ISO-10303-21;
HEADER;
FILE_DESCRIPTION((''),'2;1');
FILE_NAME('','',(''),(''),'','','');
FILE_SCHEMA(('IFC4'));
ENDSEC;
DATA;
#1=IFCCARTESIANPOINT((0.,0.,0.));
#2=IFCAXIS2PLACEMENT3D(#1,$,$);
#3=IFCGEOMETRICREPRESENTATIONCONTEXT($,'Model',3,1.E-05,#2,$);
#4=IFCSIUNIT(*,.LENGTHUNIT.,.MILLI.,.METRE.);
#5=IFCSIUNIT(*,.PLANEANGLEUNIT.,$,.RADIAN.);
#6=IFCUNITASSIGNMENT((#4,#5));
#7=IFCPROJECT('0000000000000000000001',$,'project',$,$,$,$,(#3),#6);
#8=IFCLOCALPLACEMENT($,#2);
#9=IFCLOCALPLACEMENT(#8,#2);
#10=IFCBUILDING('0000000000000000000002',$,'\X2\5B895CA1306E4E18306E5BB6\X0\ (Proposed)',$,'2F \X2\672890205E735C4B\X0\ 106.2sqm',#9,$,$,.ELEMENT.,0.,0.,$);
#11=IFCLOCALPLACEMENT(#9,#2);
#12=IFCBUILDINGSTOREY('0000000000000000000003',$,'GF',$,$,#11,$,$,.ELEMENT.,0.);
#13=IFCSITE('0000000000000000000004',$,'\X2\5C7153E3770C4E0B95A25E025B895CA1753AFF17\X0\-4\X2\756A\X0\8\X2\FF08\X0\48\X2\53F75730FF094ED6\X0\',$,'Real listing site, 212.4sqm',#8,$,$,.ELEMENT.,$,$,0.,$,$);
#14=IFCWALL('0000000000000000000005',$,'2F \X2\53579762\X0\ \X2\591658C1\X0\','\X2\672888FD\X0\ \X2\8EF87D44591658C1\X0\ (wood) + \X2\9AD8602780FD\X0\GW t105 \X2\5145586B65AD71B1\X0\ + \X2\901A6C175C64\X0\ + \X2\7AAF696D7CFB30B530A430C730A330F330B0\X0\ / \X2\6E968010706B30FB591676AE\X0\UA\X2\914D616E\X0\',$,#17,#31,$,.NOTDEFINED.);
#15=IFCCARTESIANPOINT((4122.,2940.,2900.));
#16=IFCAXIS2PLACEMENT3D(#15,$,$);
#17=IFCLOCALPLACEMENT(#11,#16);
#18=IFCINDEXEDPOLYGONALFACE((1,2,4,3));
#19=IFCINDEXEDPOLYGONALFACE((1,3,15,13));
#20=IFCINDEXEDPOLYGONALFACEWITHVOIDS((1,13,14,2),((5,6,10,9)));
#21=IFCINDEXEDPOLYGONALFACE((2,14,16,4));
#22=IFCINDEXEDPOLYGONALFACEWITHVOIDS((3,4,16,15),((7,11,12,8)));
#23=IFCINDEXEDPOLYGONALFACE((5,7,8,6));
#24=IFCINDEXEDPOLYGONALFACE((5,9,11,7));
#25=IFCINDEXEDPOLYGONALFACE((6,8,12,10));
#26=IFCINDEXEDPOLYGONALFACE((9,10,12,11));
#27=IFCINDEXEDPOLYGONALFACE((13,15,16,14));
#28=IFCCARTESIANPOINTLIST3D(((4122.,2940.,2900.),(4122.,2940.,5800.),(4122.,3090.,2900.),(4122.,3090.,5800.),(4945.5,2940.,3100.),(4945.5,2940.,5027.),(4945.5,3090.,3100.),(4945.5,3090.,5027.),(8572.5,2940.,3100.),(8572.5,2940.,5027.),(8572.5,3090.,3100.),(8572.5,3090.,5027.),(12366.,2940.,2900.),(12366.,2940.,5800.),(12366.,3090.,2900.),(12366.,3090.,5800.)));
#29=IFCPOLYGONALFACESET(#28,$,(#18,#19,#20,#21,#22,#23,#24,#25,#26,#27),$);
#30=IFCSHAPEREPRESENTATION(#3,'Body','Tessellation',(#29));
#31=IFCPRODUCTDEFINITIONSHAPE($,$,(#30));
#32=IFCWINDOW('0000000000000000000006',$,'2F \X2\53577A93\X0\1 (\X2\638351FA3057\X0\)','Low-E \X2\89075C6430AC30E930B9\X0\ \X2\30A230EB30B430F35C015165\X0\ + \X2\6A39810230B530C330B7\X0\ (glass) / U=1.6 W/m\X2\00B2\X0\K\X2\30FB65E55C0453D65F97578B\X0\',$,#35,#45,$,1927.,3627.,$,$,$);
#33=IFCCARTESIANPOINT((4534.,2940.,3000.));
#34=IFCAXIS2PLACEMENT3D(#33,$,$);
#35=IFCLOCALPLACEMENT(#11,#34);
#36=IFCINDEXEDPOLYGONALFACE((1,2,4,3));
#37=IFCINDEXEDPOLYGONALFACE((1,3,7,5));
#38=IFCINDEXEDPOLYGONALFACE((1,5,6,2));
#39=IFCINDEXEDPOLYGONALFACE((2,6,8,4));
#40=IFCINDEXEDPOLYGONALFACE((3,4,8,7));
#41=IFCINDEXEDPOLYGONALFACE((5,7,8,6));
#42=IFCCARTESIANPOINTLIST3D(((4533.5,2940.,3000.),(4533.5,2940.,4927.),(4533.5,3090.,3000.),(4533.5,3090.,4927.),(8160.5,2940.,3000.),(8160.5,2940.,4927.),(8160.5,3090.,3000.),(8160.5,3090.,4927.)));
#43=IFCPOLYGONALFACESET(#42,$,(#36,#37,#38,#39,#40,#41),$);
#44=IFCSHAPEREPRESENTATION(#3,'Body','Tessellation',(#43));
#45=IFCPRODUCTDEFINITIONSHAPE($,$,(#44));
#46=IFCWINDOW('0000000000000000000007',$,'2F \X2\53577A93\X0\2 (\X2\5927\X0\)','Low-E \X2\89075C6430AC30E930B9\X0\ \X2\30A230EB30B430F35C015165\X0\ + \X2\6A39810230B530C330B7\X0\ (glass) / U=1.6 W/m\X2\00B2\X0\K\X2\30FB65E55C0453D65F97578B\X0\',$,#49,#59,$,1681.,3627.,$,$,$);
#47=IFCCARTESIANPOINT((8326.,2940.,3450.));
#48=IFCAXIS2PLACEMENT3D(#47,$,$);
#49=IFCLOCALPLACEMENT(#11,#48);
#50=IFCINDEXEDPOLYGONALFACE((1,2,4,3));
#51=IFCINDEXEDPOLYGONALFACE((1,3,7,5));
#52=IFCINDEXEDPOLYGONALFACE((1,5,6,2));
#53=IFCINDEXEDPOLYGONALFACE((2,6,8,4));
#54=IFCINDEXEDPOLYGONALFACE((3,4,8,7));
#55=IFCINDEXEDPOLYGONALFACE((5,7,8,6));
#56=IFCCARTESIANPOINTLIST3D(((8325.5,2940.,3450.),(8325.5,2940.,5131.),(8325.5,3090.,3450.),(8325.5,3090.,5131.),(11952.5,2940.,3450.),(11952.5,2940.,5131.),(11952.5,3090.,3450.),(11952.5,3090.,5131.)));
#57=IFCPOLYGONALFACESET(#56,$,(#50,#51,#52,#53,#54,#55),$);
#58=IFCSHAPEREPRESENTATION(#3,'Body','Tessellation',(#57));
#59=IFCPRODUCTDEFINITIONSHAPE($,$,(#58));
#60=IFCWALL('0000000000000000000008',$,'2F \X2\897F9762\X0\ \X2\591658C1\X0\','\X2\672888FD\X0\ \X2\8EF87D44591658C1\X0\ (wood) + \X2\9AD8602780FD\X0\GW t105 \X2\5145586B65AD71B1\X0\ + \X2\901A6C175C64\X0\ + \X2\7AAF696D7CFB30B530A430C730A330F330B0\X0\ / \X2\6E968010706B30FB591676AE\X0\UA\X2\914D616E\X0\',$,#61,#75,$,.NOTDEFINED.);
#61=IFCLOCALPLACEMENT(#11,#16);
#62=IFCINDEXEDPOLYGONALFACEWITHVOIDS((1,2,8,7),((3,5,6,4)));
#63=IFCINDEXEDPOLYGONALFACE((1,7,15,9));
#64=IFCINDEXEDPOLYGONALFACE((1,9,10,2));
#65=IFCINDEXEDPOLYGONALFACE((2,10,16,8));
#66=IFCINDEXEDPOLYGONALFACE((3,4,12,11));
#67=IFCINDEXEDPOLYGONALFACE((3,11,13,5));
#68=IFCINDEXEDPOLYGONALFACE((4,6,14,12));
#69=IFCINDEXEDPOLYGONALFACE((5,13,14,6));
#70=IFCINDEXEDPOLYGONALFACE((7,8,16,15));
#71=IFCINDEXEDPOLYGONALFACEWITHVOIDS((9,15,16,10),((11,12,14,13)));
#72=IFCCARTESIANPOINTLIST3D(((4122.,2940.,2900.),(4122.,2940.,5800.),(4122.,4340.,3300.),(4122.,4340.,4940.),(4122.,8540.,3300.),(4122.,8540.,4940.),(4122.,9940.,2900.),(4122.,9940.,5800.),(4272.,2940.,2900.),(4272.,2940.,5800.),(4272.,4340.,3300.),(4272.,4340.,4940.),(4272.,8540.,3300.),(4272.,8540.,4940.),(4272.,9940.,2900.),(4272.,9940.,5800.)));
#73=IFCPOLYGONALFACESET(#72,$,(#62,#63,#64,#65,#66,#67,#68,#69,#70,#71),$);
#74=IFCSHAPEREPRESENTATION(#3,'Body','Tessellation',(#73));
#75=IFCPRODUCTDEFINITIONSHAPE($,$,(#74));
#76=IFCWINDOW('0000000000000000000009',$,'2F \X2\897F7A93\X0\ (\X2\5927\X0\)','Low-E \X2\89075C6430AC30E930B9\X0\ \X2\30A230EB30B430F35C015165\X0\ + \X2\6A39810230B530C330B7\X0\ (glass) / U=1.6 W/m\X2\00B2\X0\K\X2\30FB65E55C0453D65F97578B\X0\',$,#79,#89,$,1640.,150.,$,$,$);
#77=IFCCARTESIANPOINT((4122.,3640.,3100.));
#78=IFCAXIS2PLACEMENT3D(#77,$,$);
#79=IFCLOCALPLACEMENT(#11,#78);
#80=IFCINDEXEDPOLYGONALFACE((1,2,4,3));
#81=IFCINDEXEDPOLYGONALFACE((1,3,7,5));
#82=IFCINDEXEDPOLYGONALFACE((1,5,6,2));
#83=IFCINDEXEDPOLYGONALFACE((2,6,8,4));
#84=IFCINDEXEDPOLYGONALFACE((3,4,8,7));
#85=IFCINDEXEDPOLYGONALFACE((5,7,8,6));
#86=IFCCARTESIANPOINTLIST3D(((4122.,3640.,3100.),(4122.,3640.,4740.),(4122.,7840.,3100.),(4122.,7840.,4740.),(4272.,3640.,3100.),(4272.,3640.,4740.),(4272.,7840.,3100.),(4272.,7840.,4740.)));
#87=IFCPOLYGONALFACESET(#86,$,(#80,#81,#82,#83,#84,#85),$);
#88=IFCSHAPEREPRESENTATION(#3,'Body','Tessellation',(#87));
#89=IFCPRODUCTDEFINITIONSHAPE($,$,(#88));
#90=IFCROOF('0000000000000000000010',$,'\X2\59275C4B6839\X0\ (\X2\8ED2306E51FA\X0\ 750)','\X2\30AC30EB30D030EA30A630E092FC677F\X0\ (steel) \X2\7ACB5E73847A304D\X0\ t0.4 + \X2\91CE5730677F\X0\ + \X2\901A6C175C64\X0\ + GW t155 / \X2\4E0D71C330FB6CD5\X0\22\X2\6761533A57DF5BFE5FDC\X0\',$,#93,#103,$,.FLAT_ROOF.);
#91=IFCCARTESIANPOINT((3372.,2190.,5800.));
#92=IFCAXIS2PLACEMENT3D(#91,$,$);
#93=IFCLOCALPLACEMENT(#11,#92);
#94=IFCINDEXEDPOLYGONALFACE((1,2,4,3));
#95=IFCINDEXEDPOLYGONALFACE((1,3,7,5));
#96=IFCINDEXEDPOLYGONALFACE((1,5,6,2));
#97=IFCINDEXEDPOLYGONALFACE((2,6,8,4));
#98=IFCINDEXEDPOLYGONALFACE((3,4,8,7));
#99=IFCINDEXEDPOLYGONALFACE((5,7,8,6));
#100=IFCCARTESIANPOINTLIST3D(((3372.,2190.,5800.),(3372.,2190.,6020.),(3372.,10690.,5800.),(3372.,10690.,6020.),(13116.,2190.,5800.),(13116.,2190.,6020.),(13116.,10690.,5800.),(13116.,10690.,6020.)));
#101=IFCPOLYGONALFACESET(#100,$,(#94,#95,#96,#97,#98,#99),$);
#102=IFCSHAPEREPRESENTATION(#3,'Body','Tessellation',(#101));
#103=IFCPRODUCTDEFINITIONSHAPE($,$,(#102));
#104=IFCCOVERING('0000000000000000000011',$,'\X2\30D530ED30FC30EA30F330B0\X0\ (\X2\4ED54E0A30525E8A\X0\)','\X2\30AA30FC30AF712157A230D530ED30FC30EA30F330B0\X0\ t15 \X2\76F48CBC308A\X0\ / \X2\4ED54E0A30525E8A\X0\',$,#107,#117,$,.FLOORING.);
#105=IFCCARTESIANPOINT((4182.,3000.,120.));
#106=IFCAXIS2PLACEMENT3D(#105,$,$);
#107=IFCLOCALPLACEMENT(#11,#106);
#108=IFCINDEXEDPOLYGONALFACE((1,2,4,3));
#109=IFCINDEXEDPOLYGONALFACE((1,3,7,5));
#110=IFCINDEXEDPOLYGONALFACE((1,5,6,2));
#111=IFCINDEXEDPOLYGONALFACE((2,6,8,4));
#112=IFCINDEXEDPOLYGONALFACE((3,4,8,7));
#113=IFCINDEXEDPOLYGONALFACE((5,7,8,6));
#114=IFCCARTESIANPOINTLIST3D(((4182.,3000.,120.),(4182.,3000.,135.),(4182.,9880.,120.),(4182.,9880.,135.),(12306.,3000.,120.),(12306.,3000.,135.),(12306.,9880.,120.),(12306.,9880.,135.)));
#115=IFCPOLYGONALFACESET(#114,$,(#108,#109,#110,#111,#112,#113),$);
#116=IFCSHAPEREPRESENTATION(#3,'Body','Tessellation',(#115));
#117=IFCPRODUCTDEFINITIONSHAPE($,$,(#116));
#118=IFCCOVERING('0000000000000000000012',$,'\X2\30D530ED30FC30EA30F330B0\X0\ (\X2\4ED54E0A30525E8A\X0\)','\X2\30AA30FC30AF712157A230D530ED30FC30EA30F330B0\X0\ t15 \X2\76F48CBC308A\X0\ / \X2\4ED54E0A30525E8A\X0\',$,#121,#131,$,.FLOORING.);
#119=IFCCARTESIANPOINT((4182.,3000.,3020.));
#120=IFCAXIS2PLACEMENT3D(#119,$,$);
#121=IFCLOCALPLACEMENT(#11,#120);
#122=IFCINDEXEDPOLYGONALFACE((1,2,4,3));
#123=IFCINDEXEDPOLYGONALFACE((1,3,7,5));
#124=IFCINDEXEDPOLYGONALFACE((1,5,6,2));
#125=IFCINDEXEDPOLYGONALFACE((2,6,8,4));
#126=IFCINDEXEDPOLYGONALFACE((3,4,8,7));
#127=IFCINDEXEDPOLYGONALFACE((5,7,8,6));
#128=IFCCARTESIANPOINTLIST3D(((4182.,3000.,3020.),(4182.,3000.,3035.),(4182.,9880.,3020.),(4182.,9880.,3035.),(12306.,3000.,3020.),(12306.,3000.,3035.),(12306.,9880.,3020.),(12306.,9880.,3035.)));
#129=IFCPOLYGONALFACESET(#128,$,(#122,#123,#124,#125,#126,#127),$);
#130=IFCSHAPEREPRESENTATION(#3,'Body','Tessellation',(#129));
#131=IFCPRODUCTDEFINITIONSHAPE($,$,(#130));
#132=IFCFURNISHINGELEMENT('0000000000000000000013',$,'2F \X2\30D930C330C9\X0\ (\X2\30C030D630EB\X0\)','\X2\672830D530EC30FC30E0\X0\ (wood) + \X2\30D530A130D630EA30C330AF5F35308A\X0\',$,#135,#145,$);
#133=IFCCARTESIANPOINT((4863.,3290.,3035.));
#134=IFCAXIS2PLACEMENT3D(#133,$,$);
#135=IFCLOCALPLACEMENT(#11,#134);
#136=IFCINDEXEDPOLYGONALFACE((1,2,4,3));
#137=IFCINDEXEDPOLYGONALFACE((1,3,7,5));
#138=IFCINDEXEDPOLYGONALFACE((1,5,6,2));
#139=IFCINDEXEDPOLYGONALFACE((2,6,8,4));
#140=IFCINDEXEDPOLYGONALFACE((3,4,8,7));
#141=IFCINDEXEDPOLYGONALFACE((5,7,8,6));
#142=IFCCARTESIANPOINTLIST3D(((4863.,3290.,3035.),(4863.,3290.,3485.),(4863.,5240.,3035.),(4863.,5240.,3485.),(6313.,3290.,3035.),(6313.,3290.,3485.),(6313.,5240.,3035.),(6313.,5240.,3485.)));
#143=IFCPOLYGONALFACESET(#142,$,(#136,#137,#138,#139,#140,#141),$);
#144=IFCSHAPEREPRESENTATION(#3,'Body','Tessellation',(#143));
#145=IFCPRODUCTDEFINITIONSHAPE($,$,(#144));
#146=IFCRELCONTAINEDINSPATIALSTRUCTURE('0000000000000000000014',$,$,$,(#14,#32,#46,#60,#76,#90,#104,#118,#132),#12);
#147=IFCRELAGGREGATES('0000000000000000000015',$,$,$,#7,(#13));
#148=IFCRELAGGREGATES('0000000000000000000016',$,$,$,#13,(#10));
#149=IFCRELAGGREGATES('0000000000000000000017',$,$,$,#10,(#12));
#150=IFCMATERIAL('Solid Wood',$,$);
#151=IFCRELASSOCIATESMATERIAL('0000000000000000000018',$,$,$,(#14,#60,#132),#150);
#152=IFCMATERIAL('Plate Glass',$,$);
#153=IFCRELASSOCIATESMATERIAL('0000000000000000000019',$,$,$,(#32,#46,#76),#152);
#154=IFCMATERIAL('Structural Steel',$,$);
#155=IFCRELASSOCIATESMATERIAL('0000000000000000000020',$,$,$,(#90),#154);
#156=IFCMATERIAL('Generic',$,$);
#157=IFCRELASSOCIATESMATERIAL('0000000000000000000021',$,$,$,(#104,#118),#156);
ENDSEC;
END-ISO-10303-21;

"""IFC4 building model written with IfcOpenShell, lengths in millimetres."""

from ifc_helpers import new_model, si_unit, frame, frame_2d, origin, place, context, project, spatial, rectangle, extrude, material, element, fill, save


model = new_model("IFC4")

# Units and contexts
model_context = context("Model", 3, precision=1e-05, world=origin())
ifc_project = project(units=[si_unit("LENGTHUNIT", "METRE", prefix="MILLI"), si_unit("PLANEANGLEUNIT", "RADIAN")], contexts=[model_context])

# Site, building, storey
site_placement = place(None, origin())
site = spatial("IfcSite", under=ifc_project, at=site_placement, Name="山口県下関市安岡町７-4番8（48号地）他", ObjectType="Real listing site, 212.4sqm", CompositionType="ELEMENT", RefElevation=0.0)
building_placement = place(site_placement, origin())
building = spatial("IfcBuilding", under=site, at=building_placement, Name="安岡の丘の家 (Proposed)", ObjectType="2F 木造平屋 106.2sqm", CompositionType="ELEMENT", ElevationOfRefHeight=0.0, ElevationOfTerrain=0.0)
storey_placement = place(building_placement, origin())
storey = spatial("IfcBuildingStorey", under=building, at=storey_placement, Name="GF", CompositionType="ELEMENT", Elevation=0.0)

# Shared definitions
ifc_material_1 = material(Name="Solid Wood")

# Shared definitions
ifc_material_2 = material(Name="Plate Glass")

# Wall, openings, windows
wall_1_placement = place(storey_placement, frame((4122.0, 2940.0, 2900.0)))
wall_1 = element("IfcWall", 1, at=wall_1_placement, inside=storey, material=ifc_material_1, Name="2F 南面 外壁", Description="木製 軸組外壁 (wood) + 高性能GW t105 充填断熱 + 通気層 + 窯業系サイディング / 準耐火・外皮UA配慮", PredefinedType="NOTDEFINED", context=model_context, shape_type="SweptSolid", body=[
    extrude(rectangle(XDim=8244.0, YDim=150.0, at=frame_2d((4122.0, 75.0))), frame((4122.0, 2940.0, 2900.0)), (0.0, 0.0, 1.0), 2900.0),
])
opening_1_placement = place(storey_placement, frame((4534.0, 2940.0, 3000.0)))
opening_1 = element("IfcOpeningElement", 2, at=opening_1_placement, cuts=wall_1, PredefinedType="NOTDEFINED", context=model_context, shape_type="SweptSolid", body=[
    extrude(rectangle(XDim=3627.0, YDim=150.0, at=frame_2d((1813.0, 75.0))), frame((4534.0, 2940.0, 3000.0)), (0.0, 0.0, 1.0), 1927.0),
])
opening_2_placement = place(storey_placement, frame((8326.0, 2940.0, 3450.0)))
opening_2 = element("IfcOpeningElement", 3, at=opening_2_placement, cuts=wall_1, PredefinedType="NOTDEFINED", context=model_context, shape_type="SweptSolid", body=[
    extrude(rectangle(XDim=3627.0, YDim=150.0, at=frame_2d((1813.0, 75.0))), frame((8326.0, 2940.0, 3450.0)), (0.0, 0.0, 1.0), 1681.0),
])
window_1_placement = place(storey_placement, frame((4534.0, 2940.0, 3000.0)))
window_1 = element("IfcWindow", 4, at=window_1_placement, inside=storey, material=ifc_material_2, Name="2F 南窓1 (掃出し)", Description="Low-E 複層ガラス アルゴン封入 + 樹脂サッシ (glass) / U=1.6 W/m²K・日射取得型", OverallHeight=1927.0, OverallWidth=3627.0, context=model_context, shape_type="SweptSolid", body=[
    extrude(rectangle(XDim=3627.0, YDim=150.0, at=frame_2d((1813.0, 75.0))), frame((4534.0, 2940.0, 3000.0)), (0.0, 0.0, 1.0), 1927.0),
])
fill(opening_1, window_1)
window_2_placement = place(storey_placement, frame((8326.0, 2940.0, 3450.0)))
window_2 = element("IfcWindow", 5, at=window_2_placement, inside=storey, material=ifc_material_2, Name="2F 南窓2 (大)", Description="Low-E 複層ガラス アルゴン封入 + 樹脂サッシ (glass) / U=1.6 W/m²K・日射取得型", OverallHeight=1681.0, OverallWidth=3627.0, context=model_context, shape_type="SweptSolid", body=[
    extrude(rectangle(XDim=3627.0, YDim=150.0, at=frame_2d((1813.0, 75.0))), frame((8326.0, 2940.0, 3450.0)), (0.0, 0.0, 1.0), 1681.0),
])
fill(opening_2, window_2)

# Wall, opening, window
wall_2_placement = place(storey_placement, frame((4122.0, 2940.0, 2900.0)))
wall_2 = element("IfcWall", 6, at=wall_2_placement, inside=storey, material=ifc_material_1, Name="2F 西面 外壁", Description="木製 軸組外壁 (wood) + 高性能GW t105 充填断熱 + 通気層 + 窯業系サイディング / 準耐火・外皮UA配慮", PredefinedType="NOTDEFINED", context=model_context, shape_type="SweptSolid", body=[
    extrude(rectangle(XDim=150.0, YDim=7000.0, at=frame_2d((75.0, 3500.0))), frame((4122.0, 2940.0, 2900.0)), (0.0, 0.0, 1.0), 2900.0),
])
opening_3_placement = place(storey_placement, frame((4122.0, 3640.0, 3100.0)))
opening_3 = element("IfcOpeningElement", 7, at=opening_3_placement, cuts=wall_2, PredefinedType="NOTDEFINED", context=model_context, shape_type="SweptSolid", body=[
    extrude(rectangle(XDim=150.0, YDim=4200.0, at=frame_2d((75.0, 2100.0))), frame((4122.0, 3640.0, 3100.0)), (0.0, 0.0, 1.0), 1640.0),
])
window_3_placement = place(storey_placement, frame((4122.0, 3640.0, 3100.0)))
window_3 = element("IfcWindow", 8, at=window_3_placement, inside=storey, material=ifc_material_2, Name="2F 西窓 (大)", Description="Low-E 複層ガラス アルゴン封入 + 樹脂サッシ (glass) / U=1.6 W/m²K・日射取得型", OverallHeight=1640.0, OverallWidth=150.0, context=model_context, shape_type="SweptSolid", body=[
    extrude(rectangle(XDim=150.0, YDim=4200.0, at=frame_2d((75.0, 2100.0))), frame((4122.0, 3640.0, 3100.0)), (0.0, 0.0, 1.0), 1640.0),
])
fill(opening_3, window_3)

# Roof
ifc_material_3 = material(Name="Structural Steel")
roof_placement = place(storey_placement, frame((3372.0, 2190.0, 5800.0)))
element("IfcRoof", 9, at=roof_placement, inside=storey, material=ifc_material_3, Name="大屋根 (軒の出 750)", Description="ガルバリウム鋼板 (steel) 立平葺き t0.4 + 野地板 + 通気層 + GW t155 / 不燃・法22条区域対応", PredefinedType="FLAT_ROOF", context=model_context, shape_type="SweptSolid", body=[
    extrude(rectangle(XDim=9744.0, YDim=8500.0, at=frame_2d((4872.0, 4250.0))), frame((3372.0, 2190.0, 5800.0)), (0.0, 0.0, 1.0), 220.0),
])

# Coverings
ifc_material_4 = material(Name="Generic")
covering_1_placement = place(storey_placement, frame((4182.0, 3000.0, 120.0)))
element("IfcCovering", 10, at=covering_1_placement, inside=storey, material=ifc_material_4, Name="フローリング (仕上げ床)", Description="オーク無垢フローリング t15 直貼り / 仕上げ床", PredefinedType="FLOORING", context=model_context, shape_type="SweptSolid", body=[
    extrude(rectangle(XDim=8124.0, YDim=6880.0, at=frame_2d((4062.0, 3440.0))), frame((4182.0, 3000.0, 120.0)), (0.0, 0.0, 1.0), 15.0),
])
covering_2_placement = place(storey_placement, frame((4182.0, 3000.0, 3020.0)))
element("IfcCovering", 11, at=covering_2_placement, inside=storey, material=ifc_material_4, Name="フローリング (仕上げ床)", Description="オーク無垢フローリング t15 直貼り / 仕上げ床", PredefinedType="FLOORING", context=model_context, shape_type="SweptSolid", body=[
    extrude(rectangle(XDim=8124.0, YDim=6880.0, at=frame_2d((4062.0, 3440.0))), frame((4182.0, 3000.0, 3020.0)), (0.0, 0.0, 1.0), 15.0),
])

# Furnishing element
furnishing_placement = place(storey_placement, frame((4863.0, 3290.0, 3035.0)))
element("IfcFurnishingElement", 12, at=furnishing_placement, inside=storey, material=ifc_material_1, Name="2F ベッド (ダブル)", Description="木フレーム (wood) + ファブリック張り", context=model_context, shape_type="SweptSolid", body=[
    extrude(rectangle(XDim=1450.0, YDim=1950.0, at=frame_2d((725.0, 975.0))), frame((4863.0, 3290.0, 3035.0)), (0.0, 0.0, 1.0), 450.0),
])

save(model, "model.ifc")
